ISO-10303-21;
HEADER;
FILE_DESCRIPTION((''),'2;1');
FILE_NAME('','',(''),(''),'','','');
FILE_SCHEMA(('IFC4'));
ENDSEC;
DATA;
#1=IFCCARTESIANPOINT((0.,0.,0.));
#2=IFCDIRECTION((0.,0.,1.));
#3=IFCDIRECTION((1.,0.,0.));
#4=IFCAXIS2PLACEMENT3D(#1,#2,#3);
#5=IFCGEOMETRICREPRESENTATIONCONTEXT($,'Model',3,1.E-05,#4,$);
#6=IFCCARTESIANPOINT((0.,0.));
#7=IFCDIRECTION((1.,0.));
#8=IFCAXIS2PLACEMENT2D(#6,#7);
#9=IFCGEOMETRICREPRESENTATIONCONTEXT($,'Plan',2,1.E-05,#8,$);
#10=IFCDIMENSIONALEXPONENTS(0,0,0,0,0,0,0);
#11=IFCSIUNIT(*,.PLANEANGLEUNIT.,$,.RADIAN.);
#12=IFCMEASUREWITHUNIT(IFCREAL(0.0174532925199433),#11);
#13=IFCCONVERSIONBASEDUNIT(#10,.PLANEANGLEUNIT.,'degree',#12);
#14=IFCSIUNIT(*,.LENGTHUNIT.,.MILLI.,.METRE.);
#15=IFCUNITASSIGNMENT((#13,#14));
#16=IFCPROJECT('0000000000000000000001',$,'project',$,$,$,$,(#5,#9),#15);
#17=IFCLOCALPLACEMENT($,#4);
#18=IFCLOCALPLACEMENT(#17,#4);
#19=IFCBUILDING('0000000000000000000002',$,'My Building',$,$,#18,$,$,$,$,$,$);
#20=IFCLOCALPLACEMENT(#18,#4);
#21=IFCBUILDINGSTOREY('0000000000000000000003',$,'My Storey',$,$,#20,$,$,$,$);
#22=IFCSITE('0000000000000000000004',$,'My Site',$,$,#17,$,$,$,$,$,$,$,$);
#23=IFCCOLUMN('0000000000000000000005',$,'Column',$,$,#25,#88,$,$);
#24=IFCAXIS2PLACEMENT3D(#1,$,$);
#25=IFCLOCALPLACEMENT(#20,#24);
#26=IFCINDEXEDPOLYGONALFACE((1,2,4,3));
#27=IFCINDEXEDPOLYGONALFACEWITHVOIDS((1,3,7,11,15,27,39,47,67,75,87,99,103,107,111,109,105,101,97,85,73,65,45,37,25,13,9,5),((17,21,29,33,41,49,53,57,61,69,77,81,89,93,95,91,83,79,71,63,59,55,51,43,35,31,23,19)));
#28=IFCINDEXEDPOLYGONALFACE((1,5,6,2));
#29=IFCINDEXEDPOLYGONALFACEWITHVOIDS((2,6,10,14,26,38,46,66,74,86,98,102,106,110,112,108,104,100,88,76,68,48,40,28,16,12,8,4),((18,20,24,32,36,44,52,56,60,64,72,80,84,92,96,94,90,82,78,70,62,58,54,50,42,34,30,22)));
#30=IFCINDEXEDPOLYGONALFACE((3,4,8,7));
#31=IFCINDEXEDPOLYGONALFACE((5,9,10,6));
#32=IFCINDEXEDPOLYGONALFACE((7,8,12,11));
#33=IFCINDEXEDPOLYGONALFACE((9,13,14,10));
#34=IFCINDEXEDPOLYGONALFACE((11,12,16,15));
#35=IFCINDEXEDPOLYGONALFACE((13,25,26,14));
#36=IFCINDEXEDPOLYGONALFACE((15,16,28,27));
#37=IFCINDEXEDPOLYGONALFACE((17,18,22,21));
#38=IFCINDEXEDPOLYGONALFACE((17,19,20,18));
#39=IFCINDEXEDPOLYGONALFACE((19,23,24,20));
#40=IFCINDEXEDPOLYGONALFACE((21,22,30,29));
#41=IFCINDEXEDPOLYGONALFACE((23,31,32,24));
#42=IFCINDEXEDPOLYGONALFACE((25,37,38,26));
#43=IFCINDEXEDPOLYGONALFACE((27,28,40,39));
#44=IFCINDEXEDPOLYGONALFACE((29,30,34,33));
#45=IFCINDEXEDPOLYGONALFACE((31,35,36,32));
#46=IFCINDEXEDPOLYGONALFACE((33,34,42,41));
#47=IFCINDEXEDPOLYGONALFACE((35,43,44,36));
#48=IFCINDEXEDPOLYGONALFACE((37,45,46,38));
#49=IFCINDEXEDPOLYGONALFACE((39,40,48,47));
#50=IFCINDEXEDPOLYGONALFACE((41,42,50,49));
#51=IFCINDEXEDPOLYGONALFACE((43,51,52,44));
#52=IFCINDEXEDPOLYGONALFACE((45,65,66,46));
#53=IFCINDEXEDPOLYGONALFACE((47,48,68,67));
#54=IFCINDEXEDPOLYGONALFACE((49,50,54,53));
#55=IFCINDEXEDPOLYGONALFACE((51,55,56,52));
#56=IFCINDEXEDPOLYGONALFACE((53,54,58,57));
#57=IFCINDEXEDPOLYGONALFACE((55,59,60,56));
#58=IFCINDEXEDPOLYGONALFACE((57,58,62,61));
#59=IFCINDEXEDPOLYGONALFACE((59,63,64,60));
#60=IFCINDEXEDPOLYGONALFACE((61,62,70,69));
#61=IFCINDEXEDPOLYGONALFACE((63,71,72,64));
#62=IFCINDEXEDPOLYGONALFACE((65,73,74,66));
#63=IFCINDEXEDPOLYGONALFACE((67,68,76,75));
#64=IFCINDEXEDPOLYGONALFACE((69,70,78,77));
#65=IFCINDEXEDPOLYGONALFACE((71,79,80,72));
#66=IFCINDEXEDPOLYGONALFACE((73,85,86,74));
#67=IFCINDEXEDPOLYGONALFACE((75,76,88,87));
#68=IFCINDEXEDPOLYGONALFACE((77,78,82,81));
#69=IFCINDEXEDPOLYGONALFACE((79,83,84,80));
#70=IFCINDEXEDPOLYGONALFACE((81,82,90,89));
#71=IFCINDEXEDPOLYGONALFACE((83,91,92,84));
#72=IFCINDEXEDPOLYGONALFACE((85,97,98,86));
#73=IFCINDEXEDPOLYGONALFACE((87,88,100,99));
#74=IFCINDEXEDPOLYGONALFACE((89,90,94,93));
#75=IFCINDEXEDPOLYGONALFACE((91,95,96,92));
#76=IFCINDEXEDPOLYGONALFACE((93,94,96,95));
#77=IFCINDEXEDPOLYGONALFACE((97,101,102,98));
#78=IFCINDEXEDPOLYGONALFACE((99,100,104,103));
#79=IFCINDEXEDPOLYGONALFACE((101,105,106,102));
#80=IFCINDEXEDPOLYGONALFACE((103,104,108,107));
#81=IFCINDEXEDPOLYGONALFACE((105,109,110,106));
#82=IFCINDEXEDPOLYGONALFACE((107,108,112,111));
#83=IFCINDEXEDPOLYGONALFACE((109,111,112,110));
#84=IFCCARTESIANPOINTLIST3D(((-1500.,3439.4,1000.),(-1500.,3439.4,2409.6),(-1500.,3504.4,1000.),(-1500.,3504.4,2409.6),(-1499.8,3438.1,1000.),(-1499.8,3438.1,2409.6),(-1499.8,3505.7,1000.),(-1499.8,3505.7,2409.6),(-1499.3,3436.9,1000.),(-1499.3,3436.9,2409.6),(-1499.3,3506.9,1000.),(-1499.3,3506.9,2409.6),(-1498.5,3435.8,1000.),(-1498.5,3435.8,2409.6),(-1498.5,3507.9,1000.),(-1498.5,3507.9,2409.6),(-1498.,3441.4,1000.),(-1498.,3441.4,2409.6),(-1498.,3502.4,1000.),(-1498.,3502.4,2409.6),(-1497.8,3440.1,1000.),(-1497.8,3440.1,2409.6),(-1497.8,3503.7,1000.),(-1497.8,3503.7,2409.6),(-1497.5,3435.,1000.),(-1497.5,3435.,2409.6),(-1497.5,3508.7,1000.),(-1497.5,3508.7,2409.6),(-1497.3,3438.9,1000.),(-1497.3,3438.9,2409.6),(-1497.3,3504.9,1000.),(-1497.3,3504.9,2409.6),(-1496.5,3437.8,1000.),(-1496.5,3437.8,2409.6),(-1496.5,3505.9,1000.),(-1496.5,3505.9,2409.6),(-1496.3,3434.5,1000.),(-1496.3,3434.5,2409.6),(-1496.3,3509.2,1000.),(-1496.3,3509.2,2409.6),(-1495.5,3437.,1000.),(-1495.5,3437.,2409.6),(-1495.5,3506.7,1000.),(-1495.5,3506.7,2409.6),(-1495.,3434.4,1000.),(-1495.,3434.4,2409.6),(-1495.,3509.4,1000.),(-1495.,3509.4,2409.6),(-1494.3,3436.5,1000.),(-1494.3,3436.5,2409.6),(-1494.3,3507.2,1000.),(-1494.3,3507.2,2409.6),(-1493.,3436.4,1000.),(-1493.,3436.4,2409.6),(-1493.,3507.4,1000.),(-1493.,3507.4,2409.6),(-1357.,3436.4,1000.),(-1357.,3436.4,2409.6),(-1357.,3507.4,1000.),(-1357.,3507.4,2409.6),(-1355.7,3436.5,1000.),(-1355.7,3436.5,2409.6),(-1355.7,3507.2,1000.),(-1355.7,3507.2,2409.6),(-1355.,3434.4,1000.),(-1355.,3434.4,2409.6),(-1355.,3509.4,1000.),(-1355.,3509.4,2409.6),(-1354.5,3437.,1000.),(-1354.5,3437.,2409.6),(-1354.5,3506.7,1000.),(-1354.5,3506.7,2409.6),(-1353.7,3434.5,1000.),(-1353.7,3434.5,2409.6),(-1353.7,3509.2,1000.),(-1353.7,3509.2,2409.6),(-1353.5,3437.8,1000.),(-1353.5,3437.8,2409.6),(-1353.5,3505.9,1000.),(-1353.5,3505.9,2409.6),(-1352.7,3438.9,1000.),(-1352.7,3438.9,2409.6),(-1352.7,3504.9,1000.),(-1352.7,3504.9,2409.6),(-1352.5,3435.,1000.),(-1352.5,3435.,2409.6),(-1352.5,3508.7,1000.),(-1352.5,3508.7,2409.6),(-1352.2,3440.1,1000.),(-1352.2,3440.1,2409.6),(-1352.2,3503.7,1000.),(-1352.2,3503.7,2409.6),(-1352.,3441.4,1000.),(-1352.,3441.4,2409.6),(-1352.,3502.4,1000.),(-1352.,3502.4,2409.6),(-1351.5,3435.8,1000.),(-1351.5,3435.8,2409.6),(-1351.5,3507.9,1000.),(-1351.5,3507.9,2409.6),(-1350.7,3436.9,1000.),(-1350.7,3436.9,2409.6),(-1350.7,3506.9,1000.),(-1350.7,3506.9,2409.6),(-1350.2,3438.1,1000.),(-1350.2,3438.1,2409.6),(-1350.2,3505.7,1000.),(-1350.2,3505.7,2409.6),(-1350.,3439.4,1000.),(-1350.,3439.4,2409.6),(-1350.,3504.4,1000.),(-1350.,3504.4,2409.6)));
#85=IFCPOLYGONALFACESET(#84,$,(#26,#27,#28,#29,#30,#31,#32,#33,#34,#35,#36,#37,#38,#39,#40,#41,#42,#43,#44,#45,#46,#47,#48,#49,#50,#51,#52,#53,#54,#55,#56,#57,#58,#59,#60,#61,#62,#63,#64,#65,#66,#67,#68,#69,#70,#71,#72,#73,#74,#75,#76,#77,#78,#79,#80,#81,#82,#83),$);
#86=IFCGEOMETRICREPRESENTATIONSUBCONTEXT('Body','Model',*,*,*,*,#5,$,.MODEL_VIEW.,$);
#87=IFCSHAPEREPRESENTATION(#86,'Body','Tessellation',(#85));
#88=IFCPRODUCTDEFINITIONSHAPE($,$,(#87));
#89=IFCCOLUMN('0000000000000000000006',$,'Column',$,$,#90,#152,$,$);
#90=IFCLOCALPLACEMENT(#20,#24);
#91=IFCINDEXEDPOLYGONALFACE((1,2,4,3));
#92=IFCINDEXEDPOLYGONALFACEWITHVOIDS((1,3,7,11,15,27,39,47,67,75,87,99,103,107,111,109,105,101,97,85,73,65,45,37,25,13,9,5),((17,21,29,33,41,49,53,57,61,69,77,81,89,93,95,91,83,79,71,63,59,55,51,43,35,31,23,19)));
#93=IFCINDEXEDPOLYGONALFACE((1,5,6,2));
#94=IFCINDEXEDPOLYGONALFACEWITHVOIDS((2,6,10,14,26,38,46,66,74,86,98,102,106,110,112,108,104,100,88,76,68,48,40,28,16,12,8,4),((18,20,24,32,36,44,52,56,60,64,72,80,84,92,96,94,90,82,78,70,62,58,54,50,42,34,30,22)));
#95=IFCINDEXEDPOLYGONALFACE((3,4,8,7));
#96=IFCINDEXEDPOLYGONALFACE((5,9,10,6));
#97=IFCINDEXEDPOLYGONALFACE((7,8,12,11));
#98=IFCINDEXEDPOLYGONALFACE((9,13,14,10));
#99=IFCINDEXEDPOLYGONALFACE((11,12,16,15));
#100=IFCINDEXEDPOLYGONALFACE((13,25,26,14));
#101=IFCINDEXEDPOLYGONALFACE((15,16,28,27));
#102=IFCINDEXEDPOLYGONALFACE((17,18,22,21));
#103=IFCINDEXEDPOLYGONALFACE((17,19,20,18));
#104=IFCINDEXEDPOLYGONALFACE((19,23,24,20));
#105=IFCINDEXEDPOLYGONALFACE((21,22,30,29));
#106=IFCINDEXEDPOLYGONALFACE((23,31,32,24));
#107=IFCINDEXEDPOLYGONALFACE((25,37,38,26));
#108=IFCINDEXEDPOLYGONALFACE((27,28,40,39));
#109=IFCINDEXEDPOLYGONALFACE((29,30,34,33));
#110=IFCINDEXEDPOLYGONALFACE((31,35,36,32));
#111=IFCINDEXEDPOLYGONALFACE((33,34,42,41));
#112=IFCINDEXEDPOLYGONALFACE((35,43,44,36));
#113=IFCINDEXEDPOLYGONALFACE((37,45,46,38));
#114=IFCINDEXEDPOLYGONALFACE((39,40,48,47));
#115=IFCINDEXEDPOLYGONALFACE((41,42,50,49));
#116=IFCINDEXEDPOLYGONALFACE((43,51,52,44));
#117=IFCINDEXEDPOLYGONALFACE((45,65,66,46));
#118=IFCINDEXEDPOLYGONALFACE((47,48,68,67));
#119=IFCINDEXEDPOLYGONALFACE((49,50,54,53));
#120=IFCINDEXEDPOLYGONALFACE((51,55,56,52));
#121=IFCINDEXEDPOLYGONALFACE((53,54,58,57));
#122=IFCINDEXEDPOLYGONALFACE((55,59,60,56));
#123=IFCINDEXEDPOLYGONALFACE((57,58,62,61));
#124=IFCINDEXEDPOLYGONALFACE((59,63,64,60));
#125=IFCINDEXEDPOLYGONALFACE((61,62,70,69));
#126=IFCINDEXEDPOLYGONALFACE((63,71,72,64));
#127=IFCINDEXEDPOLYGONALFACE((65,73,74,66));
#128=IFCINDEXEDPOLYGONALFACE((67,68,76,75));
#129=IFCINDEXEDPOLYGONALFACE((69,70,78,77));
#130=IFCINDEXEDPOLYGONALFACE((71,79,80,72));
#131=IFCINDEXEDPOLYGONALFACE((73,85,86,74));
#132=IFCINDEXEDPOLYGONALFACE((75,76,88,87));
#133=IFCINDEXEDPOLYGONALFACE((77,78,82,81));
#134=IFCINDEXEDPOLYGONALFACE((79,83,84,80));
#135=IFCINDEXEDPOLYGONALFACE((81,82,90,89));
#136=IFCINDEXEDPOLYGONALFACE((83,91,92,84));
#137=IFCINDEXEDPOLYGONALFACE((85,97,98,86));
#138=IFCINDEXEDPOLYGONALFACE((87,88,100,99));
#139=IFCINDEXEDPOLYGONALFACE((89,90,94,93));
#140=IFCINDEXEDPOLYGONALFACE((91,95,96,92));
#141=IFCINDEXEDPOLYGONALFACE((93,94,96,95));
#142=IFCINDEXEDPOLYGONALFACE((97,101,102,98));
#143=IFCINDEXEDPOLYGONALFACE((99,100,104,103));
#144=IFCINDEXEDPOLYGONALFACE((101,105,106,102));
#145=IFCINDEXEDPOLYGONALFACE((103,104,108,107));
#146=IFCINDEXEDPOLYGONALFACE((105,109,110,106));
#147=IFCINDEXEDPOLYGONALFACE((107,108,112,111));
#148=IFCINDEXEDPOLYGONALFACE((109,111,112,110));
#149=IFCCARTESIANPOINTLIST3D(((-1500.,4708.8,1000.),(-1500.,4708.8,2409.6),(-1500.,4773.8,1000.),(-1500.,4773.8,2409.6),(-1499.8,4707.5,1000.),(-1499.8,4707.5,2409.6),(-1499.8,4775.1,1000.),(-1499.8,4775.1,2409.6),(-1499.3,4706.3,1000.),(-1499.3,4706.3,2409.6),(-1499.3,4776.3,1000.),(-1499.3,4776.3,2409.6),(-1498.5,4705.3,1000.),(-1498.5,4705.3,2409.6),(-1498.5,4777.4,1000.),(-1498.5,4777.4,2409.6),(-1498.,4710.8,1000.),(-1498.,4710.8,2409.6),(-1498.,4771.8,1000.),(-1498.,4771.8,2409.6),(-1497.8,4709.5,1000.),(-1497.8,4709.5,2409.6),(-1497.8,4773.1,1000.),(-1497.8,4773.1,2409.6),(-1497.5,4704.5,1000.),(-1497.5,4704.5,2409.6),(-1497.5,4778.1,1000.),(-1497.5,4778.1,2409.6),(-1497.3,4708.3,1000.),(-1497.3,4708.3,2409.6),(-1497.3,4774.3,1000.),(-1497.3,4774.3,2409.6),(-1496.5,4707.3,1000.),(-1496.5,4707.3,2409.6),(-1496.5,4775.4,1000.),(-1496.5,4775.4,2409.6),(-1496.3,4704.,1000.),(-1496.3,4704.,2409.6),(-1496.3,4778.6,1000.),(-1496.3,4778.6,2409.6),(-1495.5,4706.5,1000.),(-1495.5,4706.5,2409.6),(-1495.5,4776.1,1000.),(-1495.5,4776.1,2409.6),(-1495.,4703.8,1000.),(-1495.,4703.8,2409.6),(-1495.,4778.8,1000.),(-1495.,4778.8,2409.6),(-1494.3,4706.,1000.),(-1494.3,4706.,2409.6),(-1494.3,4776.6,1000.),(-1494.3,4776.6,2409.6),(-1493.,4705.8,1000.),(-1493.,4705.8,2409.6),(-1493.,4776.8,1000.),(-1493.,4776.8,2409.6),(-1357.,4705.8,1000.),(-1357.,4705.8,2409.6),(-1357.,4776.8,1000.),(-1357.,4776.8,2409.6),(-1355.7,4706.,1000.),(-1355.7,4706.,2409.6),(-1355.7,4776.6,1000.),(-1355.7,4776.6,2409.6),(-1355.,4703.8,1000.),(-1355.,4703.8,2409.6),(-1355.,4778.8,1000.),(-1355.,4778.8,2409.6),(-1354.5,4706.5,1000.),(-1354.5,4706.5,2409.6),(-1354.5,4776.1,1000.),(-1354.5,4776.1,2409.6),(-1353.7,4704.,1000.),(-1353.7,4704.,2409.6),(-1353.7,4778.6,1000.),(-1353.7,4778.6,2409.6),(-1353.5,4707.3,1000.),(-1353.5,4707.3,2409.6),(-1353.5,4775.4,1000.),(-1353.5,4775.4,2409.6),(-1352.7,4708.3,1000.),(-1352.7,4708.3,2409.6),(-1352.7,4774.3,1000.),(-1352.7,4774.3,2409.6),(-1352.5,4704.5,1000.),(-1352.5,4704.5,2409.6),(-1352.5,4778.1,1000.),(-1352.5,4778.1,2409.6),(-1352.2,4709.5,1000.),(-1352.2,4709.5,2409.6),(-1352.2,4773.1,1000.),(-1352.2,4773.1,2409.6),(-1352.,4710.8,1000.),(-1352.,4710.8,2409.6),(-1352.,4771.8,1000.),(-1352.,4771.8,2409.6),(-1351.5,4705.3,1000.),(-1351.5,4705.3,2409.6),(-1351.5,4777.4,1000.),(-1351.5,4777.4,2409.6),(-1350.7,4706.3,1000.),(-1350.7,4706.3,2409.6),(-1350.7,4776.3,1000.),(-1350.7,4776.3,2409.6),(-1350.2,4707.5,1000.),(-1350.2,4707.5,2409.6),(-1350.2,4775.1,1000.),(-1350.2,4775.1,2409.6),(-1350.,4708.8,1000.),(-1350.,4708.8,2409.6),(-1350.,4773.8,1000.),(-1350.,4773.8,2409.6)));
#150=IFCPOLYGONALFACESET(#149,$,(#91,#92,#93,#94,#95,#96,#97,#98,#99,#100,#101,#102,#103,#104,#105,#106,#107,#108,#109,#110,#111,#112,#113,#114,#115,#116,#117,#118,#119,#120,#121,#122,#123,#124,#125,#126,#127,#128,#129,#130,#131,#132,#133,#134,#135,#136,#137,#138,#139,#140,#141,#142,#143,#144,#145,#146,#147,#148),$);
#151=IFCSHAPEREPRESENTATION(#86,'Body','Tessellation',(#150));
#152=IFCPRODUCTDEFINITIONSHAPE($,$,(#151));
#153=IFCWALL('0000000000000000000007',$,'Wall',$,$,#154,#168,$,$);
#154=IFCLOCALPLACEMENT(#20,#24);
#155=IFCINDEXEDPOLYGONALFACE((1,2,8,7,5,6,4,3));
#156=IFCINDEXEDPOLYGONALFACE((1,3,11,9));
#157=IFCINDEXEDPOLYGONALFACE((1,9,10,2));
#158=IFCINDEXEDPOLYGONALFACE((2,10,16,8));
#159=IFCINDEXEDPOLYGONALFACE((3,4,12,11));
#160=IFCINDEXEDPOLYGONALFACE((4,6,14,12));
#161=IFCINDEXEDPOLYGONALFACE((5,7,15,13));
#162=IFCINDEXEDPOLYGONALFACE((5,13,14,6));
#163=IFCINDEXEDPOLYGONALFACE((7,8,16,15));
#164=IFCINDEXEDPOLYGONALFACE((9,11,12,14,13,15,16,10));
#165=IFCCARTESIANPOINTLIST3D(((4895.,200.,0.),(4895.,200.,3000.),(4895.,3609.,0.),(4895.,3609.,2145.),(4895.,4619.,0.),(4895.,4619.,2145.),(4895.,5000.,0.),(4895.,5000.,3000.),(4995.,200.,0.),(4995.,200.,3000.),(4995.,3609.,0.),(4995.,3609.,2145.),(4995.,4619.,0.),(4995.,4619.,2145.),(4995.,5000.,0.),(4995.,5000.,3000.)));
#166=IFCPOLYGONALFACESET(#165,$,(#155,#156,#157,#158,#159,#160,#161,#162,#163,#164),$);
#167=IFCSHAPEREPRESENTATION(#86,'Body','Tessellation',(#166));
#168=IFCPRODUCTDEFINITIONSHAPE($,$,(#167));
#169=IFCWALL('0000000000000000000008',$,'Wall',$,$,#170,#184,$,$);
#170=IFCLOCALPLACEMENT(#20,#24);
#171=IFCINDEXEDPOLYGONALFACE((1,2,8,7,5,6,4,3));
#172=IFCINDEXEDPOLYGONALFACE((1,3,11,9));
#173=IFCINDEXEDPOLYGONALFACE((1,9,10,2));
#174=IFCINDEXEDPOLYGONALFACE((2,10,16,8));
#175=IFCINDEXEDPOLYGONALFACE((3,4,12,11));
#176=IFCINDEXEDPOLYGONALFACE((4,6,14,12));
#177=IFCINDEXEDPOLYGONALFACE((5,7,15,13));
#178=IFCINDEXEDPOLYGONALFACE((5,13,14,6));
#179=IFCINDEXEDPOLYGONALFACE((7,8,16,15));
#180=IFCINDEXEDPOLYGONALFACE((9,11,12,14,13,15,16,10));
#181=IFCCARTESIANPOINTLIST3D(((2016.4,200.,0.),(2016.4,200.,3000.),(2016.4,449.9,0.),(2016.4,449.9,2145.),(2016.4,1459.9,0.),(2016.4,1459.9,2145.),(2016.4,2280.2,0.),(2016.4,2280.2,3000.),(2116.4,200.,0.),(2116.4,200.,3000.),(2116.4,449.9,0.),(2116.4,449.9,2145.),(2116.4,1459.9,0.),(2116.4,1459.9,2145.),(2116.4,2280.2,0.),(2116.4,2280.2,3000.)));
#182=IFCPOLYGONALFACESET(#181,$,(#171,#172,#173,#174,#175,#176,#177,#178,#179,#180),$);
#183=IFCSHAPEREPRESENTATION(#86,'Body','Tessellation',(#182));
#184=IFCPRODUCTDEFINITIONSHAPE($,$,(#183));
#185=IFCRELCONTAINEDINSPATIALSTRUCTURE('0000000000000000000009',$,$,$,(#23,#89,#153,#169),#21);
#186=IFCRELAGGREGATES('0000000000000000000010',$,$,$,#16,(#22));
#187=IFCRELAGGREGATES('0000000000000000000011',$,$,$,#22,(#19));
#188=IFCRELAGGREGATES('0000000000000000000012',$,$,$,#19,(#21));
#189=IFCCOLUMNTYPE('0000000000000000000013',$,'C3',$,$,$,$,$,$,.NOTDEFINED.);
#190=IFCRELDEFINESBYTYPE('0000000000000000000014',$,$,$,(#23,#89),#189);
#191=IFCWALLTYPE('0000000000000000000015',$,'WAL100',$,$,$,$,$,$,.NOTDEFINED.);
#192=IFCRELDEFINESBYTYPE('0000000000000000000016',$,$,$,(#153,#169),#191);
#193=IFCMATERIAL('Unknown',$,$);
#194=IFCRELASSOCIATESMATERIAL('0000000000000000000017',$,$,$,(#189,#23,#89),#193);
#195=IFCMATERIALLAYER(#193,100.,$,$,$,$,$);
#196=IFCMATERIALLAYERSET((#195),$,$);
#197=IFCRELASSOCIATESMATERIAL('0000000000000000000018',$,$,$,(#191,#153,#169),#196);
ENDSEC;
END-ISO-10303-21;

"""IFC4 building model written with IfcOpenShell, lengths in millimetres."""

from ifc_helpers import new_model, entity, si_unit, converted_unit, frame, origin_with_axes, origin_2d_with_axis, place, context, subcontext, project, spatial, line, indexed_curve, hollow_rectangle, outline, extrude, source, transform, mapped, material, layer, layer_set, layer_usage, material_profile, profile_set, profile_usage, type_object, element, save


model = new_model("IFC4")

# Units and contexts
model_context = context("Model", 3, precision=1e-05, world=origin_with_axes())
plan_context = context("Plan", 2, precision=1e-05, world=origin_2d_with_axis())
body_context = subcontext(model_context, "Body", "Model", "MODEL_VIEW")
ifc_project = project(units=[converted_unit("PLANEANGLEUNIT", "degree", entity("IfcReal", 0.0174532925199433), si_unit("PLANEANGLEUNIT", "RADIAN"), dimensions=[0, 0, 0, 0, 0, 0, 0]), si_unit("LENGTHUNIT", "METRE", prefix="MILLI")], contexts=[model_context, plan_context])

# Site, building, storey
site_placement = place(None, origin_with_axes())
site = spatial("IfcSite", under=ifc_project, at=site_placement, Name="My Site")
building_placement = place(site_placement, origin_with_axes())
building = spatial("IfcBuilding", under=site, at=building_placement, Name="My Building")
storey_placement = place(building_placement, origin_with_axes())
storey = spatial("IfcBuildingStorey", under=building, at=storey_placement, Name="My Storey")

# Columns
ifc_material = material(Name="Unknown")
ifc_material_profile = material_profile(ifc_material, hollow_rectangle(XDim=75.0, YDim=150.0, WallThickness=2.0, InnerFilletRadius=5.0, OuterFilletRadius=5.0))
ifc_profile_set = profile_set([ifc_material_profile])
ifc_profile_usage_1 = profile_usage(ifc_profile_set, cardinal=5)
column_type = type_object("IfcColumnType", Name="C3", PredefinedType="NOTDEFINED", material=ifc_profile_set)
column_1_placement = place(storey_placement, frame((-1425.0, 3471.9, 1000.0), z_axis=(0.0, 0.0, 1.0), x_axis=(0.0, 1.0, 0.0)))
element("IfcColumn", 1, at=column_1_placement, inside=storey, type_object=column_type, material=ifc_profile_usage_1, Name="Column", context=body_context, shape_type="SweptSolid", body=[
    extrude(hollow_rectangle(XDim=75.0, YDim=150.0, WallThickness=2.0, InnerFilletRadius=5.0, OuterFilletRadius=5.0), origin_with_axes(), (0.0, 0.0, 1.0), 1409.6),
])
ifc_profile_usage_2 = profile_usage(ifc_profile_set, cardinal=5)
column_2_placement = place(storey_placement, frame((-1425.0, 4741.3, 1000.0), z_axis=(0.0, 0.0, 1.0), x_axis=(0.0, 1.0, 0.0)))
element("IfcColumn", 2, at=column_2_placement, inside=storey, type_object=column_type, material=ifc_profile_usage_2, Name="Column", context=body_context, shape_type="SweptSolid", body=[
    extrude(hollow_rectangle(XDim=75.0, YDim=150.0, WallThickness=2.0, InnerFilletRadius=5.0, OuterFilletRadius=5.0), origin_with_axes(), (0.0, 0.0, 1.0), 1409.6),
])

# Walls, openings
ifc_layer_1 = layer(ifc_material, 100.0)
ifc_layer_set_1 = layer_set([ifc_layer_1])
ifc_layer_usage_1 = layer_usage(ifc_layer_set_1, "AXIS2", "POSITIVE", 0.0)
wall_type_1 = type_object("IfcWallType", Name="WAL100", PredefinedType="NOTDEFINED", material=ifc_layer_set_1)
wall_1_placement = place(storey_placement, frame((4995.0, 200.0, 0.0), z_axis=(0.0, 0.0, 1.0), x_axis=(0.0, 1.0, 0.0)))
wall_1 = element("IfcWall", 3, at=wall_1_placement, inside=storey, type_object=wall_type_1, material=ifc_layer_usage_1, Name="Wall", context=body_context, shape_type="SweptSolid", body=[
    extrude(outline(indexed_curve([(0.0, 0.0), (0.0, 100.0), (4800.0, 100.0), (4800.0, 0.0), (0.0, 0.0)], self_intersect=False)), origin_with_axes(), (0.0, 0.0, 1.0), 3000.0),
])
shared_shape_1 = source(origin_with_axes(), body_context, "Body", "SweptSolid", [
    extrude(outline(indexed_curve([(0.0, 0.0), (1010.0, 0.0), (1010.0, 2145.0), (0.0, 2145.0)], segments=[line(1, 2), line(2, 3), line(3, 4), line(4, 1)])), frame((0.0, -100.0, 0.0), z_axis=(0.0, -1.0, 0.0), x_axis=(1.0, 0.0, 0.0)), (0.0, 0.0, -1.0), 400.0),
])
opening_1_placement = place(wall_1_placement, frame((3409.0, 0.0, 0.0), z_axis=(0.0, 0.0, 1.0), x_axis=(1.0, 0.0, 0.0)))
element("IfcOpeningElement", 4, at=opening_1_placement, cuts=wall_1, PredefinedType="OPENING", context=body_context, shape_type="MappedRepresentation", body=[
    mapped(shared_shape_1, transform((0.0, 0.0, 0.0), x_axis=(1.0, 0.0, 0.0), y_axis=(0.0, 1.0, 0.0), z_axis=(0.0, 0.0, 1.0), scale=1.0)),
])
ifc_layer_usage_2 = layer_usage(ifc_layer_set_1, "AXIS2", "POSITIVE", 0.0)
wall_2_placement = place(storey_placement, frame((2116.4, 200.0, 0.0), z_axis=(0.0, 0.0, 1.0), x_axis=(0.000001, 1.0, 0.0)))
wall_2 = element("IfcWall", 5, at=wall_2_placement, inside=storey, type_object=wall_type_1, material=ifc_layer_usage_2, Name="Wall", context=body_context, shape_type="SweptSolid", body=[
    extrude(outline(indexed_curve([(0.0, 0.0), (0.0, 100.0), (2080.2, 100.0), (2080.2, 0.0), (0.0, 0.0)], self_intersect=False)), origin_with_axes(), (0.0, 0.0, 1.0), 3000.0),
])
opening_2_placement = place(wall_2_placement, frame((249.9, 0.0, 0.0), z_axis=(0.0, 0.0, 1.0), x_axis=(1.0, 0.0, 0.0)))
element("IfcOpeningElement", 6, at=opening_2_placement, cuts=wall_2, PredefinedType="OPENING", context=body_context, shape_type="MappedRepresentation", body=[
    mapped(shared_shape_1, transform((0.0, 0.0, 0.0), x_axis=(1.0, 0.0, 0.0), y_axis=(0.0, 1.0, 0.0), z_axis=(0.0, 0.0, 1.0), scale=1.0)),
])

save(model, "model.ifc")
